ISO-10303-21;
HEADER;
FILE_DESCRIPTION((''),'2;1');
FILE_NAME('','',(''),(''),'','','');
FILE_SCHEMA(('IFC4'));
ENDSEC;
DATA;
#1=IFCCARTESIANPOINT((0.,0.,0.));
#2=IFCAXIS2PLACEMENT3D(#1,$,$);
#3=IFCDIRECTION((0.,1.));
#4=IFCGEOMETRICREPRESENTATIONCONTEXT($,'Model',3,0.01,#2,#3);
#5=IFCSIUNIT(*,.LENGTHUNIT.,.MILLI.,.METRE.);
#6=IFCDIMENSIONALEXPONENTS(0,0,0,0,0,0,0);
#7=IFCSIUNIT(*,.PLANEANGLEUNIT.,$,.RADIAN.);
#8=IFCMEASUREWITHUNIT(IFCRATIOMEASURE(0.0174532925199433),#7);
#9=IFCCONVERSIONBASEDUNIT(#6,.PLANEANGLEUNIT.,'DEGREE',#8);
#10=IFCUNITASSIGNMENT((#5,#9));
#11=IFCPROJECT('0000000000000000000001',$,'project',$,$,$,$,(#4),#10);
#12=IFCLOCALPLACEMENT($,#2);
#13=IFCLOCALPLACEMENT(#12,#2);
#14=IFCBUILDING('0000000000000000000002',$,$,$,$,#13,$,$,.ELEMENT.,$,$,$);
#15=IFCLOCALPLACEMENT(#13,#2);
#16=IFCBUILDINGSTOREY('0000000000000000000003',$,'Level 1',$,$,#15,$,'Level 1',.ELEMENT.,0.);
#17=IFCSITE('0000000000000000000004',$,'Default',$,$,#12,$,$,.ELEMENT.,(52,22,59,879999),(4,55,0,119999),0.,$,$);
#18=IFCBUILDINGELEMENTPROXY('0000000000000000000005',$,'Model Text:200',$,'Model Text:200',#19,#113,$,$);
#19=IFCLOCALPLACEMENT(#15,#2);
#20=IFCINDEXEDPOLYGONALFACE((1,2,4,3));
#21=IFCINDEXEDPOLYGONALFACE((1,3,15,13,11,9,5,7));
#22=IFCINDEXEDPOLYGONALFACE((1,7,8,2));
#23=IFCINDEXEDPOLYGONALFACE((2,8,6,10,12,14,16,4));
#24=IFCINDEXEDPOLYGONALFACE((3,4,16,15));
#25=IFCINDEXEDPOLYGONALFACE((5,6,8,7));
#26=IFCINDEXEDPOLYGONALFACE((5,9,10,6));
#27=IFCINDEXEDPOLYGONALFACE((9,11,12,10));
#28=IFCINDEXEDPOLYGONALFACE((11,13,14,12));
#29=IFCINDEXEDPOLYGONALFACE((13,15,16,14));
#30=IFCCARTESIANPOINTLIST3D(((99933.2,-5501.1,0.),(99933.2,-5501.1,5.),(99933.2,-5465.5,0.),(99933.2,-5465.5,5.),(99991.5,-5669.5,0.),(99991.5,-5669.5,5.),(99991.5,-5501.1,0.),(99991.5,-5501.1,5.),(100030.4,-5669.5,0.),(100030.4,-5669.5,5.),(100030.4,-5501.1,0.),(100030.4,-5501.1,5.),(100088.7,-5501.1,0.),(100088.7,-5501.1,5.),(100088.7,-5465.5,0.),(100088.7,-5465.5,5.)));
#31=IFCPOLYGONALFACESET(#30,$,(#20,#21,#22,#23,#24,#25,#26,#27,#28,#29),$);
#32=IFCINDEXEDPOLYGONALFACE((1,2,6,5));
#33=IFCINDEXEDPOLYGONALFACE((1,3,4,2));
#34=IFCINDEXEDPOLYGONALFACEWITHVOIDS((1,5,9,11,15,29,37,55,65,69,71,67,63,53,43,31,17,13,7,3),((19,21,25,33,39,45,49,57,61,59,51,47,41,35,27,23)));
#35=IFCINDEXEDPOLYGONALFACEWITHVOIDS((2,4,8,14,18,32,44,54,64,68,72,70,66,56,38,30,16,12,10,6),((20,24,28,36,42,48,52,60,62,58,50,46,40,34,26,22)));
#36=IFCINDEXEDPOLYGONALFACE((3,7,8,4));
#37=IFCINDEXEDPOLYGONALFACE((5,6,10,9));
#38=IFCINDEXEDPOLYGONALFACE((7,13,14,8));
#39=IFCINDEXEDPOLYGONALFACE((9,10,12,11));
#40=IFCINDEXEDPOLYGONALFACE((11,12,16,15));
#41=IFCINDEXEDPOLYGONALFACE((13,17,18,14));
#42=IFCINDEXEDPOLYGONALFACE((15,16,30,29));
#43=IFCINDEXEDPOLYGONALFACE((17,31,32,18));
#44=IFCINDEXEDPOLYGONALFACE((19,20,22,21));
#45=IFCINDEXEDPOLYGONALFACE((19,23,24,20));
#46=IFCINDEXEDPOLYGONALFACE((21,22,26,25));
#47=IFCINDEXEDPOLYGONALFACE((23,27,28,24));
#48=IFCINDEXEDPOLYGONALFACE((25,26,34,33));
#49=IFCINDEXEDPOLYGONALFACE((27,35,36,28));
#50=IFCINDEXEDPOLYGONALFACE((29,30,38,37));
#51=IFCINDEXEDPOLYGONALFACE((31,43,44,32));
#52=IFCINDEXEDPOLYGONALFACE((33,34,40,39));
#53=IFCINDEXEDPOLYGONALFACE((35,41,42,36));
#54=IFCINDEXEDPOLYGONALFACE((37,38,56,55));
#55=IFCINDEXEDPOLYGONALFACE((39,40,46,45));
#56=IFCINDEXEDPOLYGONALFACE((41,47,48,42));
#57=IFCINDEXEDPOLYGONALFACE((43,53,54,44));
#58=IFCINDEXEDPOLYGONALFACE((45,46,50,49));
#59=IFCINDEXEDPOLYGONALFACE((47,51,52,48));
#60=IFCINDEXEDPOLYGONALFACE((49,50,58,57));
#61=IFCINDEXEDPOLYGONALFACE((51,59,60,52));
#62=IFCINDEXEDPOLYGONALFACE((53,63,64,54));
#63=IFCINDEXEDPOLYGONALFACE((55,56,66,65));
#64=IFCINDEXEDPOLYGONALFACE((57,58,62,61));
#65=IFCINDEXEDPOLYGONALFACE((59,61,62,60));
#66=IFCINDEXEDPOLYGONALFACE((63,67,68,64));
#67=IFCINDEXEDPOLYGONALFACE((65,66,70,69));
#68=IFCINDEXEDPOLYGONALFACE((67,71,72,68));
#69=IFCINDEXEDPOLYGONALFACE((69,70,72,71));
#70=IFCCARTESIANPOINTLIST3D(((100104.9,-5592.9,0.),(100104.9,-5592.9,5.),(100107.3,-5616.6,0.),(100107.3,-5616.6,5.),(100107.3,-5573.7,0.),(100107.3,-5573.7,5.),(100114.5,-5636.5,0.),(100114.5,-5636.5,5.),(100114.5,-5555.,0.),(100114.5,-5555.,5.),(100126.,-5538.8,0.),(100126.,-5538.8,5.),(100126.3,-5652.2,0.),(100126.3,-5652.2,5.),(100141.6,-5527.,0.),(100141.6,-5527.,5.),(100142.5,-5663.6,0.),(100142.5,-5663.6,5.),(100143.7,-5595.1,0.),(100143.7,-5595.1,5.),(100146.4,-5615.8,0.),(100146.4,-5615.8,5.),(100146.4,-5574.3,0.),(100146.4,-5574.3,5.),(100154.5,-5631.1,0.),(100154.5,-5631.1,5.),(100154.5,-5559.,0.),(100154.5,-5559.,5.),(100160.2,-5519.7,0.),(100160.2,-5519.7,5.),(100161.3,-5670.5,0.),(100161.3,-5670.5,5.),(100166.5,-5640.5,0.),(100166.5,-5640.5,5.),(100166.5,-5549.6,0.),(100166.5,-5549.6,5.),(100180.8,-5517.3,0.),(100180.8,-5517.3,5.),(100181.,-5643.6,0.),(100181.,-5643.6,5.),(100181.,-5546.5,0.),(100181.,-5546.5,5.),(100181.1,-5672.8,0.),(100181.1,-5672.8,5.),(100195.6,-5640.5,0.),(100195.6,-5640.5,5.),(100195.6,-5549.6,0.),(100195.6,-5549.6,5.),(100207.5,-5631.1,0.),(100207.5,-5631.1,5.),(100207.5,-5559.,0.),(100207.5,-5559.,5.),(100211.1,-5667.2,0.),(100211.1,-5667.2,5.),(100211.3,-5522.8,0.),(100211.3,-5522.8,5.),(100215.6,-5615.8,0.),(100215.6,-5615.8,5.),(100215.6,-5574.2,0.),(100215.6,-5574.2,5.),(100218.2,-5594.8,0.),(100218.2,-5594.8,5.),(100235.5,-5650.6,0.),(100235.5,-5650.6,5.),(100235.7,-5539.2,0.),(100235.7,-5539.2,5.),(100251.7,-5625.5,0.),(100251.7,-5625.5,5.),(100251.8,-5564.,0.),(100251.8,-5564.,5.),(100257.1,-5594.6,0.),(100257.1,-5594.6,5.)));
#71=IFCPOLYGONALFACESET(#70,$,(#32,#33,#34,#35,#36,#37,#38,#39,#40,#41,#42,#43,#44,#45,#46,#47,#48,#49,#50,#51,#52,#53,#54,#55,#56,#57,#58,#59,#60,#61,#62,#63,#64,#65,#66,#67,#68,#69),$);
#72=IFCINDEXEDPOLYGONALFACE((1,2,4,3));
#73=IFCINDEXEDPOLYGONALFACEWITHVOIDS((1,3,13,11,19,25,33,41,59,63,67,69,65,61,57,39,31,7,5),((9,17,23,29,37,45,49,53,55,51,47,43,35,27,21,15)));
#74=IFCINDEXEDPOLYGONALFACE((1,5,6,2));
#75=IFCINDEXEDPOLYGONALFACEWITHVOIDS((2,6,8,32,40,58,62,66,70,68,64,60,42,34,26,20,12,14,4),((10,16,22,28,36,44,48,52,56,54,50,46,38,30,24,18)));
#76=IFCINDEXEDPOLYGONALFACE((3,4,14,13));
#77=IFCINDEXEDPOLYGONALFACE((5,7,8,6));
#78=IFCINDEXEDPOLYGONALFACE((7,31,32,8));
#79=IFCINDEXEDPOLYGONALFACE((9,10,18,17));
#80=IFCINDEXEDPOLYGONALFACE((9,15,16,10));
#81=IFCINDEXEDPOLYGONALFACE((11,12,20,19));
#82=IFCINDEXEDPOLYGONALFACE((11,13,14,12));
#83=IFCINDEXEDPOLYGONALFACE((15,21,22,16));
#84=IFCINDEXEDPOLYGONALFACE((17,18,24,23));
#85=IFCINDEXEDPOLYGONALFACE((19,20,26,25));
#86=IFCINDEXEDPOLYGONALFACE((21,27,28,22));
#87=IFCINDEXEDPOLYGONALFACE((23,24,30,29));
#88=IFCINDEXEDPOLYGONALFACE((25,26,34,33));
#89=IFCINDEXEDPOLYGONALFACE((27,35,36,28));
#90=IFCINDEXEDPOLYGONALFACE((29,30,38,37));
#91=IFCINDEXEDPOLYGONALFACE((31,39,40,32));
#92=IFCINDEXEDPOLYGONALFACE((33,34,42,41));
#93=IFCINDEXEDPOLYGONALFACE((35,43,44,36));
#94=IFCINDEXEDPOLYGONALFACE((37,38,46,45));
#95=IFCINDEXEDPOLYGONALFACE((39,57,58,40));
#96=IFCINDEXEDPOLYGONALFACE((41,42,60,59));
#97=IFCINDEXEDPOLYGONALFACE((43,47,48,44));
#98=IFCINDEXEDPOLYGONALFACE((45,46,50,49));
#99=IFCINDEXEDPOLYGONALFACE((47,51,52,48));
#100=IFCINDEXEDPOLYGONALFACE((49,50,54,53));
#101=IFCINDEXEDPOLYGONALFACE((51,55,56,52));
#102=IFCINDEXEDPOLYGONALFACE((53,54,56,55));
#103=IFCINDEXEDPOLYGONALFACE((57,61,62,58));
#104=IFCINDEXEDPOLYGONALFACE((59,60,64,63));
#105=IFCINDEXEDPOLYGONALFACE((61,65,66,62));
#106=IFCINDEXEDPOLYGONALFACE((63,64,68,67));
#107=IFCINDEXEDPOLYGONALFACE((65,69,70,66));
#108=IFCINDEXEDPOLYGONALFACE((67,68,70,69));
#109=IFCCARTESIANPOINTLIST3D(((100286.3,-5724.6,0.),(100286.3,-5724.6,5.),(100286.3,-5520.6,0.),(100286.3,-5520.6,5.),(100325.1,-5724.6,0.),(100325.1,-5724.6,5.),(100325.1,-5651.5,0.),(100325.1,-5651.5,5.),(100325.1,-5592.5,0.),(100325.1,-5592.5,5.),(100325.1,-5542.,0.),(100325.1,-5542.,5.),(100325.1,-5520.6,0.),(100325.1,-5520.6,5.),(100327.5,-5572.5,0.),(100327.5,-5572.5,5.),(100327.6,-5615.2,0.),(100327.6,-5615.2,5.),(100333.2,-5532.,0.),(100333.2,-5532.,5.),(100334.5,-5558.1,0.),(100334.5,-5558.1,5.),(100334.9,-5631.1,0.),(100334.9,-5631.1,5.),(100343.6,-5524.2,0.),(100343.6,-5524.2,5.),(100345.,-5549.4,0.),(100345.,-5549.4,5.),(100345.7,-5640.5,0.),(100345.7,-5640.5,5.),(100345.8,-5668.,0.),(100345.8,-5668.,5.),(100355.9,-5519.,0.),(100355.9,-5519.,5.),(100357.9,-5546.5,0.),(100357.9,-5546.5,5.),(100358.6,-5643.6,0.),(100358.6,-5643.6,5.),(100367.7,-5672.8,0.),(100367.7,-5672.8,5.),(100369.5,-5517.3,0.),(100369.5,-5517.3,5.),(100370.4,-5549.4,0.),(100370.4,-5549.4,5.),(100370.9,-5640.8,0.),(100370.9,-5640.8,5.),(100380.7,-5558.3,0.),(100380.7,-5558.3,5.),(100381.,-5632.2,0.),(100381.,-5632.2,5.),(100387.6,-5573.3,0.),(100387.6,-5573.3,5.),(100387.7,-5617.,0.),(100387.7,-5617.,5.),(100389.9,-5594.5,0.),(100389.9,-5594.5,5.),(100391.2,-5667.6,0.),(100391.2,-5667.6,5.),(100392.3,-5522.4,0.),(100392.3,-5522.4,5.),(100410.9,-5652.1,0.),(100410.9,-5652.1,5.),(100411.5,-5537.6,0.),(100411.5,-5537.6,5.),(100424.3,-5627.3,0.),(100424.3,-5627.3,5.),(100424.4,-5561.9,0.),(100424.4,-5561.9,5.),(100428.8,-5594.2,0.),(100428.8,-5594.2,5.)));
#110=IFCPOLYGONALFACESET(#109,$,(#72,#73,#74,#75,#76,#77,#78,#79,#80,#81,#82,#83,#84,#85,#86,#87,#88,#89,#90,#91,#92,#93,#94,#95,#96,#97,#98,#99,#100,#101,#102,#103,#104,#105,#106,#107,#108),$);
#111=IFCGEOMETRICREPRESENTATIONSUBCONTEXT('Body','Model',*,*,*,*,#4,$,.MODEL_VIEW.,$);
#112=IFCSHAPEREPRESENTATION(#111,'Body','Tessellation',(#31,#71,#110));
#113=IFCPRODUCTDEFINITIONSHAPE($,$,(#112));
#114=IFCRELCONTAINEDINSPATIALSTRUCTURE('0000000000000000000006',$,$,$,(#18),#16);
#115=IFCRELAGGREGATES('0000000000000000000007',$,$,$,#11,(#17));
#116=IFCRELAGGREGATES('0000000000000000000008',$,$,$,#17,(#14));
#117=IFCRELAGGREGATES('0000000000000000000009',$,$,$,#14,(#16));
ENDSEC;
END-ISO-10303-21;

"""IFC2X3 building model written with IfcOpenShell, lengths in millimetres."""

from ifc_helpers import new_model, entity, si_unit, converted_unit, direction, frame, origin, place, context, subcontext, project, spatial, polyline, outline, extrude, element, save


model = new_model("IFC2X3")

# Units and contexts
model_context = context("Model", 3, precision=0.01, world=origin(), true_north=direction((0.0, 1.0)))
body_context = subcontext(model_context, "Body", "Model", "MODEL_VIEW")
ifc_project = project(units=[si_unit("LENGTHUNIT", "METRE", prefix="MILLI"), converted_unit("PLANEANGLEUNIT", "DEGREE", entity("IfcRatioMeasure", 0.0174532925199433), si_unit("PLANEANGLEUNIT", "RADIAN"), dimensions=[0, 0, 0, 0, 0, 0, 0])], contexts=[model_context])

# Site, building, storey
site_placement = place(None, origin())
site = spatial("IfcSite", under=ifc_project, at=site_placement, Name="Default", CompositionType="ELEMENT", RefLatitude=(52, 22, 59, 879999), RefLongitude=(4, 55, 0, 119999), RefElevation=0.0)
building_placement = place(site_placement, origin())
building = spatial("IfcBuilding", under=site, at=building_placement, CompositionType="ELEMENT")
storey_placement = place(building_placement, origin())
storey = spatial("IfcBuildingStorey", under=building, at=storey_placement, Name="Level 1", LongName="Level 1", CompositionType="ELEMENT", Elevation=0.0)

# Building element proxy
proxy_1_placement = place(building_placement, origin())
element("IfcBuildingElementProxy", 1, at=proxy_1_placement, inside=storey, Name="Model Text:200", ObjectType="Model Text:200", context=body_context, shape_type="SweptSolid", body=[
    extrude(outline(polyline([(-19.4, -135.2), (19.4, -135.2), (19.4, 33.2), (77.7, 33.2), (77.7, 68.8), (-77.7, 68.8), (-77.7, 33.2), (-19.4, 33.2), (-19.4, -135.2)])), frame((100010.9, -5534.3, 0.0)), (0.0, 0.0, 1.0), 5.0),
    extrude(outline(polyline([(-8.8, -65.7), (15.1, -65.7), (35.5, -60.5), (52.3, -50.4), (65.3, -35.4), (74.1, -17.3), (78.4, 2.1), (75.9, 32.5), (61.8, 58.5), (38.4, 77.1), (8.3, 85.6), (-22.7, 83.3), (-49.0, 69.9), (-67.8, 47.3), (-76.3, 17.5), (-76.0, -3.3), (-70.7, -22.5), (-60.5, -39.2), (-45.5, -52.3), (-27.7, -61.4), (-8.8, -65.7)]), holes=[polyline([(-2.7, -27.2), (-23.1, -22.5), (-37.5, -12.9), (-45.7, 0.0), (-47.3, 14.8), (-42.7, 28.9), (-32.2, 39.9), (-16.3, 46.3), (4.5, 46.9), (25.1, 42.1), (39.6, 32.6), (47.7, 19.7), (49.4, 5.0), (44.8, -9.2), (34.2, -20.2), (18.2, -26.7), (-2.7, -27.2)])]), frame((100171.1, -5595.0, 0.0), z_axis=(0.0, 0.0, 1.0), x_axis=(0.100608, -0.994926, 0.0)), (0.0, 0.0, 1.0), 5.0),
    extrude(outline(polyline([(-73.1, -75.4), (130.9, -75.4), (130.9, -36.6), (57.8, -36.6), (74.3, -15.9), (79.1, 6.0), (73.9, 29.5), (58.4, 49.2), (33.6, 62.6), (0.5, 67.1), (-31.8, 62.8), (-56.1, 49.8), (-71.3, 30.7), (-76.4, 7.8), (-74.7, -5.8), (-69.6, -18.1), (-61.7, -28.5), (-51.7, -36.6), (-73.1, -36.6), (-73.1, -75.4)]), holes=[polyline([(-1.2, -36.6), (-21.2, -34.2), (-35.6, -27.2), (-44.3, -16.7), (-47.2, -3.8), (-44.3, 8.7), (-35.4, 19.0), (-20.4, 25.9), (0.8, 28.2), (23.3, 26.0), (38.5, 19.3), (47.1, 9.2), (49.9, -3.1), (46.8, -16.0), (37.4, -26.8), (21.5, -34.1), (-1.2, -36.6)])]), frame((100361.7, -5593.7, 0.0), z_axis=(0.0, 0.0, 1.0), x_axis=(0.0, -1.0, 0.0)), (0.0, 0.0, 1.0), 5.0),
])

save(model, "model.ifc")
